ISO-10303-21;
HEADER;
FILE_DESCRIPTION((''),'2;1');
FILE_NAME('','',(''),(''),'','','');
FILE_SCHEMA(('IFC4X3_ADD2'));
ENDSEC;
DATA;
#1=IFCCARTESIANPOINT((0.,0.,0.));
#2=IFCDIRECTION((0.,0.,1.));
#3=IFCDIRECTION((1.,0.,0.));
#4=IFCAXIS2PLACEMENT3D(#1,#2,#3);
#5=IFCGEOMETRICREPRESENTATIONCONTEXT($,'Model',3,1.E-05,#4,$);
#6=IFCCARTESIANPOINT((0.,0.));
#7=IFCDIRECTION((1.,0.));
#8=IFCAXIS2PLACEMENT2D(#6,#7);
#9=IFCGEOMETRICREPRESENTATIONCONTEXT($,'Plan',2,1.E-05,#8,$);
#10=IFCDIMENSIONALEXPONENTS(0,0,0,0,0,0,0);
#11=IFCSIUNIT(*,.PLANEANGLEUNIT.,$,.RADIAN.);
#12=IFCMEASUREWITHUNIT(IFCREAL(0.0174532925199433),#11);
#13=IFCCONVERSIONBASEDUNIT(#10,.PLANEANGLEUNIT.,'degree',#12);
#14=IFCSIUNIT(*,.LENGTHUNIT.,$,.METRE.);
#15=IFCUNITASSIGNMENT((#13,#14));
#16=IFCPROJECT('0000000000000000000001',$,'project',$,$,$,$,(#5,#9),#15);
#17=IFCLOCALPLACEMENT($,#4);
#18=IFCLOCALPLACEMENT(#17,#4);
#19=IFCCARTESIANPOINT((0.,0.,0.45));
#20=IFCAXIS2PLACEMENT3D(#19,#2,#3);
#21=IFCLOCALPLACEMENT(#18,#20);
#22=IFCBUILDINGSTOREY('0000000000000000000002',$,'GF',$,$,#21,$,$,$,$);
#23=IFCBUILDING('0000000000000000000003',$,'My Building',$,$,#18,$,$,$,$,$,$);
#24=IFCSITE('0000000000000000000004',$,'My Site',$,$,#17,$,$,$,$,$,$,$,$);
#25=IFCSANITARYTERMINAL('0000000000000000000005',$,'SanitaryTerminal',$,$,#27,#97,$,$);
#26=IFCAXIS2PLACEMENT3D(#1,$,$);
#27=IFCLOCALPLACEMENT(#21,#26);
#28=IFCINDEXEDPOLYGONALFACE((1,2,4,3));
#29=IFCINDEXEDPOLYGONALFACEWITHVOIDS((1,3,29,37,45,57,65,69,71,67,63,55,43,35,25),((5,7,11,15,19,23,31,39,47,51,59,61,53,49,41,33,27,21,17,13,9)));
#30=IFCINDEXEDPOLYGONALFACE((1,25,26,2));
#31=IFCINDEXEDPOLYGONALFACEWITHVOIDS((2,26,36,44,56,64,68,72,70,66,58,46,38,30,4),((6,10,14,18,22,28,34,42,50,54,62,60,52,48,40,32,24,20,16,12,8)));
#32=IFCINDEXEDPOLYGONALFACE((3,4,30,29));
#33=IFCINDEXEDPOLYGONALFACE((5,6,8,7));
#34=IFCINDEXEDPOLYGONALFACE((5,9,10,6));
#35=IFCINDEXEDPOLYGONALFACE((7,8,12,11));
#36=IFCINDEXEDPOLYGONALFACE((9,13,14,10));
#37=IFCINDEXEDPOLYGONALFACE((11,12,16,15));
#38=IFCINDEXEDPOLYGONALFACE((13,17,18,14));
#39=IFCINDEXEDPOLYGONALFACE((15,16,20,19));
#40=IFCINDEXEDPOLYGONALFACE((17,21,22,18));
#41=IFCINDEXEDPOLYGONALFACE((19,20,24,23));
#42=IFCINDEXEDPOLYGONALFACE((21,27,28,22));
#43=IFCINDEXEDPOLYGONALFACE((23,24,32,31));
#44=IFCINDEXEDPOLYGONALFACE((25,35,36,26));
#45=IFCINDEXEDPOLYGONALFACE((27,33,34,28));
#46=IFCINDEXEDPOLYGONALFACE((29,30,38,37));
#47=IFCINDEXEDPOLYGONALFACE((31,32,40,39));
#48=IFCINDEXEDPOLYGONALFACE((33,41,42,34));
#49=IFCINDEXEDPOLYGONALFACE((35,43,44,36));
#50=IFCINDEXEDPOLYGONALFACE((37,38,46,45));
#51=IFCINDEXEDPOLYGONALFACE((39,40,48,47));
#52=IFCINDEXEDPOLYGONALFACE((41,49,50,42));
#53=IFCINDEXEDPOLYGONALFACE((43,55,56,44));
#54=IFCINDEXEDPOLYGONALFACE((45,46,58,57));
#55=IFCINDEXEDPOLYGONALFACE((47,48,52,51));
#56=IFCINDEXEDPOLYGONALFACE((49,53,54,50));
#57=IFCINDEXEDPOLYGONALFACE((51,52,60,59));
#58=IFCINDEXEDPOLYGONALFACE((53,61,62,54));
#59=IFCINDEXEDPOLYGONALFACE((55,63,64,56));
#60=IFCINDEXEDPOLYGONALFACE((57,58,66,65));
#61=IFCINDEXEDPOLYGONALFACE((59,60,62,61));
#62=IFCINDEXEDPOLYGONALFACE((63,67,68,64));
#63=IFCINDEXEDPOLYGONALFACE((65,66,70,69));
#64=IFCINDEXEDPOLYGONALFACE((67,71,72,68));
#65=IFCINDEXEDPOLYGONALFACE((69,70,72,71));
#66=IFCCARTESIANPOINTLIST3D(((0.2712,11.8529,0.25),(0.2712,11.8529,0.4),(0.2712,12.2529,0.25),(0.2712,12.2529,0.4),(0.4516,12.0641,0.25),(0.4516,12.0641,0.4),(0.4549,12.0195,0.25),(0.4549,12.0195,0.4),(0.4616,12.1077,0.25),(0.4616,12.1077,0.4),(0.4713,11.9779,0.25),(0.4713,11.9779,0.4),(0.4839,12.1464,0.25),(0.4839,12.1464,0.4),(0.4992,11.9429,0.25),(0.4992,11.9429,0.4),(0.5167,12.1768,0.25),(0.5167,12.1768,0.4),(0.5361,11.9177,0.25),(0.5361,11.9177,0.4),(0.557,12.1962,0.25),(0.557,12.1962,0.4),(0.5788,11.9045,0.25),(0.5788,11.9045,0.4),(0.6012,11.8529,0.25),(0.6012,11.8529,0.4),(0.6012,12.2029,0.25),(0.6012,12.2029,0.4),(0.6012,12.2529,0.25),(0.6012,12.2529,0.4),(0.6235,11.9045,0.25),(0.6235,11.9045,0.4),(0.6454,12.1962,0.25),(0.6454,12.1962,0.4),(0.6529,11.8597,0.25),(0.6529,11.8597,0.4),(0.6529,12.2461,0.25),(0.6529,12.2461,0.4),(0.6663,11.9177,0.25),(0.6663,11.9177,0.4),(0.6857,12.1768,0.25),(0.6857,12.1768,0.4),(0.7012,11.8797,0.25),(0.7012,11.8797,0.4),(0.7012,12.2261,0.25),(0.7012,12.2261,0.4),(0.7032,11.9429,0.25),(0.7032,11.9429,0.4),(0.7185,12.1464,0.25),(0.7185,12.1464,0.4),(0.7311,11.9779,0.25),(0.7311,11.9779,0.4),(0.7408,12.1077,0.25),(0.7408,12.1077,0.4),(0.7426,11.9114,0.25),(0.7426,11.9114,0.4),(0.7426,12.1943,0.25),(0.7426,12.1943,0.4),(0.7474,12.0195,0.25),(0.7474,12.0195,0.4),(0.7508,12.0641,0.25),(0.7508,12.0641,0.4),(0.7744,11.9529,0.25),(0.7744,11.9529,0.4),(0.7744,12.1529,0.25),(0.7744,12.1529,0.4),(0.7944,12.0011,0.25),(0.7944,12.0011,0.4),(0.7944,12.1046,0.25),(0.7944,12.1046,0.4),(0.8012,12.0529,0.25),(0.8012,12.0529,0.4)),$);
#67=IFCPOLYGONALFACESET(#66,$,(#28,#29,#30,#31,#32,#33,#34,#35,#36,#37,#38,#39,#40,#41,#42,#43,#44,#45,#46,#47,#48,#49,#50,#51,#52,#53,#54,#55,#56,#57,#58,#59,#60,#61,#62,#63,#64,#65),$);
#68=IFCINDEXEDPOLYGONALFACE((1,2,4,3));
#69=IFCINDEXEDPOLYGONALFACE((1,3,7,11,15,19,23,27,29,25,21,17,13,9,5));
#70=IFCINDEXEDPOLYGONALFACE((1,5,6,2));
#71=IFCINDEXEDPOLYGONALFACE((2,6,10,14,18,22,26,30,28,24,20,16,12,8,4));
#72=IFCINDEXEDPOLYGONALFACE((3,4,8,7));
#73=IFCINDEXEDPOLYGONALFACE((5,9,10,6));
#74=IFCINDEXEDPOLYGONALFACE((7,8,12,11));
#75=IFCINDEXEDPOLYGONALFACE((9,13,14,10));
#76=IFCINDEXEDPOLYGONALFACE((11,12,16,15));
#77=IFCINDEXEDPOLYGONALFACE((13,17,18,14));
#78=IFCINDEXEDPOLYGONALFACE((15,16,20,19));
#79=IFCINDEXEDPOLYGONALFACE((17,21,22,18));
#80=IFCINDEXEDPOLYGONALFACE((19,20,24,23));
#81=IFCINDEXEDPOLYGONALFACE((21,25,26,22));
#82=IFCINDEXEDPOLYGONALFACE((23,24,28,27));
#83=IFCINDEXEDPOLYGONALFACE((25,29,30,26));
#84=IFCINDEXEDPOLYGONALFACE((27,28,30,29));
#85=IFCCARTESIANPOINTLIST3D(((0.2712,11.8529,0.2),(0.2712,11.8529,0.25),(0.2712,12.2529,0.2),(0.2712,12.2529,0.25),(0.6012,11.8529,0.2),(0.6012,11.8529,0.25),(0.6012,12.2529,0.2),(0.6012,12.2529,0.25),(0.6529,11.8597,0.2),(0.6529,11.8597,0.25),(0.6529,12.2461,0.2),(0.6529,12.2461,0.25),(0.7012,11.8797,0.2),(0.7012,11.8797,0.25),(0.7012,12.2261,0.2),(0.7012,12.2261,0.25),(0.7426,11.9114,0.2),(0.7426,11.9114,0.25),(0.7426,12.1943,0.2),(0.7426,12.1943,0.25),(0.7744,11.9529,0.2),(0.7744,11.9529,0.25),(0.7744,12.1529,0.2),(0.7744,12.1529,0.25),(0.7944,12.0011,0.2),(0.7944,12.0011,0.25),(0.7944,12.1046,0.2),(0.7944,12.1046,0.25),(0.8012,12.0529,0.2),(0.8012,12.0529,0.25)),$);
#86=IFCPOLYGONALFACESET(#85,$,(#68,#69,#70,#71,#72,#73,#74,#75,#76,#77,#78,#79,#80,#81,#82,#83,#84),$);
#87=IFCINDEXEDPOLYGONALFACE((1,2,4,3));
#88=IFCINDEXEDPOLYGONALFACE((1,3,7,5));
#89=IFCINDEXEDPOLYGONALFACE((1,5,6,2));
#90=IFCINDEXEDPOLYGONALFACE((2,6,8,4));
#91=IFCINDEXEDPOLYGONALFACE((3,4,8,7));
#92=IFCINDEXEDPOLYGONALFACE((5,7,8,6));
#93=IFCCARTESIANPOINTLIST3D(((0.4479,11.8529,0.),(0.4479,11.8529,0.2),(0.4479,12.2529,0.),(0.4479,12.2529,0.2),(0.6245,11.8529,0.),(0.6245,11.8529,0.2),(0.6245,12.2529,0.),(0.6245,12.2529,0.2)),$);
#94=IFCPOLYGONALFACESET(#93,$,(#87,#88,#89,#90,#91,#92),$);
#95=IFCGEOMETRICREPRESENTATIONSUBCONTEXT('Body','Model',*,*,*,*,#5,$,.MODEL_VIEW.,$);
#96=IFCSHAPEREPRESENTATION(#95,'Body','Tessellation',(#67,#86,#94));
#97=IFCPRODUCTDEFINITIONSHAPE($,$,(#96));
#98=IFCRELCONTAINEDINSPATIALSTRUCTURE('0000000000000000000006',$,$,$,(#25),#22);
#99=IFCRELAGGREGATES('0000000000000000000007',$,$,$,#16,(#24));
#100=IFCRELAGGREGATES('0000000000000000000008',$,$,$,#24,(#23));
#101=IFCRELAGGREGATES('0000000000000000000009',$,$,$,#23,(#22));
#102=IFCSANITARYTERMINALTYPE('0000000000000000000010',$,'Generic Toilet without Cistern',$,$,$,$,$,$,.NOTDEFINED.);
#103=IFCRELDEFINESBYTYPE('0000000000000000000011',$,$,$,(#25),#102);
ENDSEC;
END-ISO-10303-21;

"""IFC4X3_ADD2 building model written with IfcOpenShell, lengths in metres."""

from ifc_helpers import new_model, entity, si_unit, converted_unit, frame, frame_2d, origin_with_axes, origin_2d_with_axis, place, context, subcontext, project, spatial, line, arc, indexed_curve, circle_curve, outline, extrude, shape, source, transform, mapped, type_object, type_shapes, element, save


model = new_model("IFC4X3_ADD2")

# Units and contexts
model_context = context("Model", 3, precision=1e-05, world=origin_with_axes())
plan_context = context("Plan", 2, precision=1e-05, world=origin_2d_with_axis())
body_context_1 = subcontext(model_context, "Body", "Model", "MODEL_VIEW")
body_context_2 = subcontext(plan_context, "Body", "Plan", "PLAN_VIEW")
ifc_project = project(units=[converted_unit("PLANEANGLEUNIT", "degree", entity("IfcReal", 0.0174532925199433), si_unit("PLANEANGLEUNIT", "RADIAN"), dimensions=[0, 0, 0, 0, 0, 0, 0]), si_unit("LENGTHUNIT", "METRE")], contexts=[model_context, plan_context])

# Site, building, storey
site_placement = place(None, origin_with_axes())
site = spatial("IfcSite", under=ifc_project, at=site_placement, Name="My Site")
building_placement = place(site_placement, origin_with_axes())
building = spatial("IfcBuilding", under=site, at=building_placement, Name="My Building")
storey_placement = place(building_placement, frame((0.0, 0.0, 0.45), z_axis=(0.0, 0.0, 1.0), x_axis=(1.0, 0.0, 0.0)))
storey = spatial("IfcBuildingStorey", under=building, at=storey_placement, Name="GF")

# Sanitary terminal
sanitary_terminal_type_1 = type_object("IfcSanitaryTerminalType", Name="Generic Toilet without Cistern", PredefinedType="NOTDEFINED")
shared_shape_1 = source(origin_with_axes(), body_context_1, "Body", "SweptSolid", [
    extrude(outline(indexed_curve([(-0.2, 0.0), (0.2, 0.0), (0.2, -0.33), (0.1414, -0.4714), (0.0, -0.53), (-0.1414, -0.4714), (-0.2, -0.33)], segments=[line(1, 2), line(2, 3), arc(3, 4, 5), arc(5, 6, 7), line(7, 1)]), holes=[circle_curve(frame_2d((0.0, -0.33)), 0.15)]), frame((0.0, 0.0, 0.25), z_axis=(0.0, 0.0, 1.0), x_axis=(1.0, 0.0, 0.0)), (0.0, 0.0, 1.0), 0.15),
    extrude(outline(indexed_curve([(-0.2, 0.0), (0.2, 0.0), (0.2, -0.33), (0.1414, -0.4714), (0.0, -0.53), (-0.1414, -0.4714), (-0.2, -0.33)], segments=[line(1, 2), line(2, 3), arc(3, 4, 5), arc(5, 6, 7), line(7, 1)])), frame((0.0, 0.0, 0.2), z_axis=(0.0, 0.0, 1.0), x_axis=(1.0, 0.0, 0.0)), (0.0, 0.0, 1.0), 0.05),
    extrude(outline(indexed_curve([(-0.2, -0.1767), (0.2, -0.1767), (0.2, -0.3533), (-0.2, -0.3533)], segments=[line(1, 2, 3, 4, 1)])), origin_with_axes(), (0.0, 0.0, 1.0), 0.2),
])
shared_shape_2 = source(origin_with_axes(), body_context_2, "Body", "Annotation2D", [
    entity("IfcGeometricCurveSet", [entity("IfcIndexedPolyCurve", entity("IfcCartesianPointList2D", [[-0.1068, -0.124], [-0.0957, -0.1129], [-0.0804, -0.1088], [0.0804, -0.1088], [0.0957, -0.1129], [0.1068, -0.124], [0.1109, -0.1393], [0.1109, -0.3476], [0.1025, -0.3926], [0.0784, -0.4308], [0.0424, -0.4563], [0.0, -0.4652], [-0.0424, -0.4563], [-0.0784, -0.4308], [-0.1025, -0.3926], [-0.1109, -0.3476], [-0.1109, -0.1393]]), [entity("IfcLineIndex", [1, 2, 3, 4, 5, 6, 7, 8, 9, 10, 11, 12, 13, 14, 15, 16, 17, 1])]), entity("IfcIndexedPolyCurve", entity("IfcCartesianPointList2D", [[-0.1962, -0.2314], [-0.1848, -0.301], [-0.1764, -0.3339], [-0.1663, -0.3651], [-0.1546, -0.3944], [-0.1414, -0.4213], [-0.1269, -0.4458], [-0.1111, -0.4675], [-0.0943, -0.4862], [-0.0765, -0.5018], [-0.0581, -0.514], [-0.039, -0.5229], [-0.0196, -0.5282], [0.0, -0.53], [0.0196, -0.5282], [0.039, -0.5229], [0.0581, -0.514], [0.0765, -0.5018], [0.0943, -0.4862], [0.1111, -0.4675], [0.1269, -0.4458], [0.1414, -0.4213], [0.1546, -0.3944], [0.1663, -0.3651], [0.1764, -0.3339], [0.1848, -0.301], [0.1962, -0.2314], [0.2, -0.159], [0.1872, 0.0], [-0.1872, 0.0], [-0.2, -0.159]]), [entity("IfcLineIndex", [1, 2, 3, 4, 5, 6, 7, 8, 9, 10, 11, 12, 13, 14, 15, 16, 17, 18, 19, 20, 21, 22, 23, 24, 25, 26, 27, 28, 29, 30, 31, 1])])]),
])
type_shapes(sanitary_terminal_type_1, [shared_shape_1, shared_shape_2])
sanitary_terminal_placement = place(storey_placement, frame((0.2712, 12.0529, 0.0), z_axis=(0.0, 0.0, 1.0), x_axis=(0.0, 1.0, 0.0)))
element("IfcSanitaryTerminal", 1, at=sanitary_terminal_placement, inside=storey, type_object=sanitary_terminal_type_1, Name="SanitaryTerminal", shapes=[
    shape(body_context_1, "Body", "MappedRepresentation", [mapped(shared_shape_1, transform((0.0, 0.0, 0.0), x_axis=(1.0, 0.0, 0.0), y_axis=(0.0, 1.0, 0.0), z_axis=(0.0, 0.0, 1.0), scale=1.0))]),
    shape(body_context_2, "Body", "MappedRepresentation", [mapped(shared_shape_2, transform((0.0, 0.0, 0.0), x_axis=(1.0, 0.0, 0.0), y_axis=(0.0, 1.0, 0.0), z_axis=(0.0, 0.0, 1.0), scale=1.0))]),
])

save(model, "model.ifc")
